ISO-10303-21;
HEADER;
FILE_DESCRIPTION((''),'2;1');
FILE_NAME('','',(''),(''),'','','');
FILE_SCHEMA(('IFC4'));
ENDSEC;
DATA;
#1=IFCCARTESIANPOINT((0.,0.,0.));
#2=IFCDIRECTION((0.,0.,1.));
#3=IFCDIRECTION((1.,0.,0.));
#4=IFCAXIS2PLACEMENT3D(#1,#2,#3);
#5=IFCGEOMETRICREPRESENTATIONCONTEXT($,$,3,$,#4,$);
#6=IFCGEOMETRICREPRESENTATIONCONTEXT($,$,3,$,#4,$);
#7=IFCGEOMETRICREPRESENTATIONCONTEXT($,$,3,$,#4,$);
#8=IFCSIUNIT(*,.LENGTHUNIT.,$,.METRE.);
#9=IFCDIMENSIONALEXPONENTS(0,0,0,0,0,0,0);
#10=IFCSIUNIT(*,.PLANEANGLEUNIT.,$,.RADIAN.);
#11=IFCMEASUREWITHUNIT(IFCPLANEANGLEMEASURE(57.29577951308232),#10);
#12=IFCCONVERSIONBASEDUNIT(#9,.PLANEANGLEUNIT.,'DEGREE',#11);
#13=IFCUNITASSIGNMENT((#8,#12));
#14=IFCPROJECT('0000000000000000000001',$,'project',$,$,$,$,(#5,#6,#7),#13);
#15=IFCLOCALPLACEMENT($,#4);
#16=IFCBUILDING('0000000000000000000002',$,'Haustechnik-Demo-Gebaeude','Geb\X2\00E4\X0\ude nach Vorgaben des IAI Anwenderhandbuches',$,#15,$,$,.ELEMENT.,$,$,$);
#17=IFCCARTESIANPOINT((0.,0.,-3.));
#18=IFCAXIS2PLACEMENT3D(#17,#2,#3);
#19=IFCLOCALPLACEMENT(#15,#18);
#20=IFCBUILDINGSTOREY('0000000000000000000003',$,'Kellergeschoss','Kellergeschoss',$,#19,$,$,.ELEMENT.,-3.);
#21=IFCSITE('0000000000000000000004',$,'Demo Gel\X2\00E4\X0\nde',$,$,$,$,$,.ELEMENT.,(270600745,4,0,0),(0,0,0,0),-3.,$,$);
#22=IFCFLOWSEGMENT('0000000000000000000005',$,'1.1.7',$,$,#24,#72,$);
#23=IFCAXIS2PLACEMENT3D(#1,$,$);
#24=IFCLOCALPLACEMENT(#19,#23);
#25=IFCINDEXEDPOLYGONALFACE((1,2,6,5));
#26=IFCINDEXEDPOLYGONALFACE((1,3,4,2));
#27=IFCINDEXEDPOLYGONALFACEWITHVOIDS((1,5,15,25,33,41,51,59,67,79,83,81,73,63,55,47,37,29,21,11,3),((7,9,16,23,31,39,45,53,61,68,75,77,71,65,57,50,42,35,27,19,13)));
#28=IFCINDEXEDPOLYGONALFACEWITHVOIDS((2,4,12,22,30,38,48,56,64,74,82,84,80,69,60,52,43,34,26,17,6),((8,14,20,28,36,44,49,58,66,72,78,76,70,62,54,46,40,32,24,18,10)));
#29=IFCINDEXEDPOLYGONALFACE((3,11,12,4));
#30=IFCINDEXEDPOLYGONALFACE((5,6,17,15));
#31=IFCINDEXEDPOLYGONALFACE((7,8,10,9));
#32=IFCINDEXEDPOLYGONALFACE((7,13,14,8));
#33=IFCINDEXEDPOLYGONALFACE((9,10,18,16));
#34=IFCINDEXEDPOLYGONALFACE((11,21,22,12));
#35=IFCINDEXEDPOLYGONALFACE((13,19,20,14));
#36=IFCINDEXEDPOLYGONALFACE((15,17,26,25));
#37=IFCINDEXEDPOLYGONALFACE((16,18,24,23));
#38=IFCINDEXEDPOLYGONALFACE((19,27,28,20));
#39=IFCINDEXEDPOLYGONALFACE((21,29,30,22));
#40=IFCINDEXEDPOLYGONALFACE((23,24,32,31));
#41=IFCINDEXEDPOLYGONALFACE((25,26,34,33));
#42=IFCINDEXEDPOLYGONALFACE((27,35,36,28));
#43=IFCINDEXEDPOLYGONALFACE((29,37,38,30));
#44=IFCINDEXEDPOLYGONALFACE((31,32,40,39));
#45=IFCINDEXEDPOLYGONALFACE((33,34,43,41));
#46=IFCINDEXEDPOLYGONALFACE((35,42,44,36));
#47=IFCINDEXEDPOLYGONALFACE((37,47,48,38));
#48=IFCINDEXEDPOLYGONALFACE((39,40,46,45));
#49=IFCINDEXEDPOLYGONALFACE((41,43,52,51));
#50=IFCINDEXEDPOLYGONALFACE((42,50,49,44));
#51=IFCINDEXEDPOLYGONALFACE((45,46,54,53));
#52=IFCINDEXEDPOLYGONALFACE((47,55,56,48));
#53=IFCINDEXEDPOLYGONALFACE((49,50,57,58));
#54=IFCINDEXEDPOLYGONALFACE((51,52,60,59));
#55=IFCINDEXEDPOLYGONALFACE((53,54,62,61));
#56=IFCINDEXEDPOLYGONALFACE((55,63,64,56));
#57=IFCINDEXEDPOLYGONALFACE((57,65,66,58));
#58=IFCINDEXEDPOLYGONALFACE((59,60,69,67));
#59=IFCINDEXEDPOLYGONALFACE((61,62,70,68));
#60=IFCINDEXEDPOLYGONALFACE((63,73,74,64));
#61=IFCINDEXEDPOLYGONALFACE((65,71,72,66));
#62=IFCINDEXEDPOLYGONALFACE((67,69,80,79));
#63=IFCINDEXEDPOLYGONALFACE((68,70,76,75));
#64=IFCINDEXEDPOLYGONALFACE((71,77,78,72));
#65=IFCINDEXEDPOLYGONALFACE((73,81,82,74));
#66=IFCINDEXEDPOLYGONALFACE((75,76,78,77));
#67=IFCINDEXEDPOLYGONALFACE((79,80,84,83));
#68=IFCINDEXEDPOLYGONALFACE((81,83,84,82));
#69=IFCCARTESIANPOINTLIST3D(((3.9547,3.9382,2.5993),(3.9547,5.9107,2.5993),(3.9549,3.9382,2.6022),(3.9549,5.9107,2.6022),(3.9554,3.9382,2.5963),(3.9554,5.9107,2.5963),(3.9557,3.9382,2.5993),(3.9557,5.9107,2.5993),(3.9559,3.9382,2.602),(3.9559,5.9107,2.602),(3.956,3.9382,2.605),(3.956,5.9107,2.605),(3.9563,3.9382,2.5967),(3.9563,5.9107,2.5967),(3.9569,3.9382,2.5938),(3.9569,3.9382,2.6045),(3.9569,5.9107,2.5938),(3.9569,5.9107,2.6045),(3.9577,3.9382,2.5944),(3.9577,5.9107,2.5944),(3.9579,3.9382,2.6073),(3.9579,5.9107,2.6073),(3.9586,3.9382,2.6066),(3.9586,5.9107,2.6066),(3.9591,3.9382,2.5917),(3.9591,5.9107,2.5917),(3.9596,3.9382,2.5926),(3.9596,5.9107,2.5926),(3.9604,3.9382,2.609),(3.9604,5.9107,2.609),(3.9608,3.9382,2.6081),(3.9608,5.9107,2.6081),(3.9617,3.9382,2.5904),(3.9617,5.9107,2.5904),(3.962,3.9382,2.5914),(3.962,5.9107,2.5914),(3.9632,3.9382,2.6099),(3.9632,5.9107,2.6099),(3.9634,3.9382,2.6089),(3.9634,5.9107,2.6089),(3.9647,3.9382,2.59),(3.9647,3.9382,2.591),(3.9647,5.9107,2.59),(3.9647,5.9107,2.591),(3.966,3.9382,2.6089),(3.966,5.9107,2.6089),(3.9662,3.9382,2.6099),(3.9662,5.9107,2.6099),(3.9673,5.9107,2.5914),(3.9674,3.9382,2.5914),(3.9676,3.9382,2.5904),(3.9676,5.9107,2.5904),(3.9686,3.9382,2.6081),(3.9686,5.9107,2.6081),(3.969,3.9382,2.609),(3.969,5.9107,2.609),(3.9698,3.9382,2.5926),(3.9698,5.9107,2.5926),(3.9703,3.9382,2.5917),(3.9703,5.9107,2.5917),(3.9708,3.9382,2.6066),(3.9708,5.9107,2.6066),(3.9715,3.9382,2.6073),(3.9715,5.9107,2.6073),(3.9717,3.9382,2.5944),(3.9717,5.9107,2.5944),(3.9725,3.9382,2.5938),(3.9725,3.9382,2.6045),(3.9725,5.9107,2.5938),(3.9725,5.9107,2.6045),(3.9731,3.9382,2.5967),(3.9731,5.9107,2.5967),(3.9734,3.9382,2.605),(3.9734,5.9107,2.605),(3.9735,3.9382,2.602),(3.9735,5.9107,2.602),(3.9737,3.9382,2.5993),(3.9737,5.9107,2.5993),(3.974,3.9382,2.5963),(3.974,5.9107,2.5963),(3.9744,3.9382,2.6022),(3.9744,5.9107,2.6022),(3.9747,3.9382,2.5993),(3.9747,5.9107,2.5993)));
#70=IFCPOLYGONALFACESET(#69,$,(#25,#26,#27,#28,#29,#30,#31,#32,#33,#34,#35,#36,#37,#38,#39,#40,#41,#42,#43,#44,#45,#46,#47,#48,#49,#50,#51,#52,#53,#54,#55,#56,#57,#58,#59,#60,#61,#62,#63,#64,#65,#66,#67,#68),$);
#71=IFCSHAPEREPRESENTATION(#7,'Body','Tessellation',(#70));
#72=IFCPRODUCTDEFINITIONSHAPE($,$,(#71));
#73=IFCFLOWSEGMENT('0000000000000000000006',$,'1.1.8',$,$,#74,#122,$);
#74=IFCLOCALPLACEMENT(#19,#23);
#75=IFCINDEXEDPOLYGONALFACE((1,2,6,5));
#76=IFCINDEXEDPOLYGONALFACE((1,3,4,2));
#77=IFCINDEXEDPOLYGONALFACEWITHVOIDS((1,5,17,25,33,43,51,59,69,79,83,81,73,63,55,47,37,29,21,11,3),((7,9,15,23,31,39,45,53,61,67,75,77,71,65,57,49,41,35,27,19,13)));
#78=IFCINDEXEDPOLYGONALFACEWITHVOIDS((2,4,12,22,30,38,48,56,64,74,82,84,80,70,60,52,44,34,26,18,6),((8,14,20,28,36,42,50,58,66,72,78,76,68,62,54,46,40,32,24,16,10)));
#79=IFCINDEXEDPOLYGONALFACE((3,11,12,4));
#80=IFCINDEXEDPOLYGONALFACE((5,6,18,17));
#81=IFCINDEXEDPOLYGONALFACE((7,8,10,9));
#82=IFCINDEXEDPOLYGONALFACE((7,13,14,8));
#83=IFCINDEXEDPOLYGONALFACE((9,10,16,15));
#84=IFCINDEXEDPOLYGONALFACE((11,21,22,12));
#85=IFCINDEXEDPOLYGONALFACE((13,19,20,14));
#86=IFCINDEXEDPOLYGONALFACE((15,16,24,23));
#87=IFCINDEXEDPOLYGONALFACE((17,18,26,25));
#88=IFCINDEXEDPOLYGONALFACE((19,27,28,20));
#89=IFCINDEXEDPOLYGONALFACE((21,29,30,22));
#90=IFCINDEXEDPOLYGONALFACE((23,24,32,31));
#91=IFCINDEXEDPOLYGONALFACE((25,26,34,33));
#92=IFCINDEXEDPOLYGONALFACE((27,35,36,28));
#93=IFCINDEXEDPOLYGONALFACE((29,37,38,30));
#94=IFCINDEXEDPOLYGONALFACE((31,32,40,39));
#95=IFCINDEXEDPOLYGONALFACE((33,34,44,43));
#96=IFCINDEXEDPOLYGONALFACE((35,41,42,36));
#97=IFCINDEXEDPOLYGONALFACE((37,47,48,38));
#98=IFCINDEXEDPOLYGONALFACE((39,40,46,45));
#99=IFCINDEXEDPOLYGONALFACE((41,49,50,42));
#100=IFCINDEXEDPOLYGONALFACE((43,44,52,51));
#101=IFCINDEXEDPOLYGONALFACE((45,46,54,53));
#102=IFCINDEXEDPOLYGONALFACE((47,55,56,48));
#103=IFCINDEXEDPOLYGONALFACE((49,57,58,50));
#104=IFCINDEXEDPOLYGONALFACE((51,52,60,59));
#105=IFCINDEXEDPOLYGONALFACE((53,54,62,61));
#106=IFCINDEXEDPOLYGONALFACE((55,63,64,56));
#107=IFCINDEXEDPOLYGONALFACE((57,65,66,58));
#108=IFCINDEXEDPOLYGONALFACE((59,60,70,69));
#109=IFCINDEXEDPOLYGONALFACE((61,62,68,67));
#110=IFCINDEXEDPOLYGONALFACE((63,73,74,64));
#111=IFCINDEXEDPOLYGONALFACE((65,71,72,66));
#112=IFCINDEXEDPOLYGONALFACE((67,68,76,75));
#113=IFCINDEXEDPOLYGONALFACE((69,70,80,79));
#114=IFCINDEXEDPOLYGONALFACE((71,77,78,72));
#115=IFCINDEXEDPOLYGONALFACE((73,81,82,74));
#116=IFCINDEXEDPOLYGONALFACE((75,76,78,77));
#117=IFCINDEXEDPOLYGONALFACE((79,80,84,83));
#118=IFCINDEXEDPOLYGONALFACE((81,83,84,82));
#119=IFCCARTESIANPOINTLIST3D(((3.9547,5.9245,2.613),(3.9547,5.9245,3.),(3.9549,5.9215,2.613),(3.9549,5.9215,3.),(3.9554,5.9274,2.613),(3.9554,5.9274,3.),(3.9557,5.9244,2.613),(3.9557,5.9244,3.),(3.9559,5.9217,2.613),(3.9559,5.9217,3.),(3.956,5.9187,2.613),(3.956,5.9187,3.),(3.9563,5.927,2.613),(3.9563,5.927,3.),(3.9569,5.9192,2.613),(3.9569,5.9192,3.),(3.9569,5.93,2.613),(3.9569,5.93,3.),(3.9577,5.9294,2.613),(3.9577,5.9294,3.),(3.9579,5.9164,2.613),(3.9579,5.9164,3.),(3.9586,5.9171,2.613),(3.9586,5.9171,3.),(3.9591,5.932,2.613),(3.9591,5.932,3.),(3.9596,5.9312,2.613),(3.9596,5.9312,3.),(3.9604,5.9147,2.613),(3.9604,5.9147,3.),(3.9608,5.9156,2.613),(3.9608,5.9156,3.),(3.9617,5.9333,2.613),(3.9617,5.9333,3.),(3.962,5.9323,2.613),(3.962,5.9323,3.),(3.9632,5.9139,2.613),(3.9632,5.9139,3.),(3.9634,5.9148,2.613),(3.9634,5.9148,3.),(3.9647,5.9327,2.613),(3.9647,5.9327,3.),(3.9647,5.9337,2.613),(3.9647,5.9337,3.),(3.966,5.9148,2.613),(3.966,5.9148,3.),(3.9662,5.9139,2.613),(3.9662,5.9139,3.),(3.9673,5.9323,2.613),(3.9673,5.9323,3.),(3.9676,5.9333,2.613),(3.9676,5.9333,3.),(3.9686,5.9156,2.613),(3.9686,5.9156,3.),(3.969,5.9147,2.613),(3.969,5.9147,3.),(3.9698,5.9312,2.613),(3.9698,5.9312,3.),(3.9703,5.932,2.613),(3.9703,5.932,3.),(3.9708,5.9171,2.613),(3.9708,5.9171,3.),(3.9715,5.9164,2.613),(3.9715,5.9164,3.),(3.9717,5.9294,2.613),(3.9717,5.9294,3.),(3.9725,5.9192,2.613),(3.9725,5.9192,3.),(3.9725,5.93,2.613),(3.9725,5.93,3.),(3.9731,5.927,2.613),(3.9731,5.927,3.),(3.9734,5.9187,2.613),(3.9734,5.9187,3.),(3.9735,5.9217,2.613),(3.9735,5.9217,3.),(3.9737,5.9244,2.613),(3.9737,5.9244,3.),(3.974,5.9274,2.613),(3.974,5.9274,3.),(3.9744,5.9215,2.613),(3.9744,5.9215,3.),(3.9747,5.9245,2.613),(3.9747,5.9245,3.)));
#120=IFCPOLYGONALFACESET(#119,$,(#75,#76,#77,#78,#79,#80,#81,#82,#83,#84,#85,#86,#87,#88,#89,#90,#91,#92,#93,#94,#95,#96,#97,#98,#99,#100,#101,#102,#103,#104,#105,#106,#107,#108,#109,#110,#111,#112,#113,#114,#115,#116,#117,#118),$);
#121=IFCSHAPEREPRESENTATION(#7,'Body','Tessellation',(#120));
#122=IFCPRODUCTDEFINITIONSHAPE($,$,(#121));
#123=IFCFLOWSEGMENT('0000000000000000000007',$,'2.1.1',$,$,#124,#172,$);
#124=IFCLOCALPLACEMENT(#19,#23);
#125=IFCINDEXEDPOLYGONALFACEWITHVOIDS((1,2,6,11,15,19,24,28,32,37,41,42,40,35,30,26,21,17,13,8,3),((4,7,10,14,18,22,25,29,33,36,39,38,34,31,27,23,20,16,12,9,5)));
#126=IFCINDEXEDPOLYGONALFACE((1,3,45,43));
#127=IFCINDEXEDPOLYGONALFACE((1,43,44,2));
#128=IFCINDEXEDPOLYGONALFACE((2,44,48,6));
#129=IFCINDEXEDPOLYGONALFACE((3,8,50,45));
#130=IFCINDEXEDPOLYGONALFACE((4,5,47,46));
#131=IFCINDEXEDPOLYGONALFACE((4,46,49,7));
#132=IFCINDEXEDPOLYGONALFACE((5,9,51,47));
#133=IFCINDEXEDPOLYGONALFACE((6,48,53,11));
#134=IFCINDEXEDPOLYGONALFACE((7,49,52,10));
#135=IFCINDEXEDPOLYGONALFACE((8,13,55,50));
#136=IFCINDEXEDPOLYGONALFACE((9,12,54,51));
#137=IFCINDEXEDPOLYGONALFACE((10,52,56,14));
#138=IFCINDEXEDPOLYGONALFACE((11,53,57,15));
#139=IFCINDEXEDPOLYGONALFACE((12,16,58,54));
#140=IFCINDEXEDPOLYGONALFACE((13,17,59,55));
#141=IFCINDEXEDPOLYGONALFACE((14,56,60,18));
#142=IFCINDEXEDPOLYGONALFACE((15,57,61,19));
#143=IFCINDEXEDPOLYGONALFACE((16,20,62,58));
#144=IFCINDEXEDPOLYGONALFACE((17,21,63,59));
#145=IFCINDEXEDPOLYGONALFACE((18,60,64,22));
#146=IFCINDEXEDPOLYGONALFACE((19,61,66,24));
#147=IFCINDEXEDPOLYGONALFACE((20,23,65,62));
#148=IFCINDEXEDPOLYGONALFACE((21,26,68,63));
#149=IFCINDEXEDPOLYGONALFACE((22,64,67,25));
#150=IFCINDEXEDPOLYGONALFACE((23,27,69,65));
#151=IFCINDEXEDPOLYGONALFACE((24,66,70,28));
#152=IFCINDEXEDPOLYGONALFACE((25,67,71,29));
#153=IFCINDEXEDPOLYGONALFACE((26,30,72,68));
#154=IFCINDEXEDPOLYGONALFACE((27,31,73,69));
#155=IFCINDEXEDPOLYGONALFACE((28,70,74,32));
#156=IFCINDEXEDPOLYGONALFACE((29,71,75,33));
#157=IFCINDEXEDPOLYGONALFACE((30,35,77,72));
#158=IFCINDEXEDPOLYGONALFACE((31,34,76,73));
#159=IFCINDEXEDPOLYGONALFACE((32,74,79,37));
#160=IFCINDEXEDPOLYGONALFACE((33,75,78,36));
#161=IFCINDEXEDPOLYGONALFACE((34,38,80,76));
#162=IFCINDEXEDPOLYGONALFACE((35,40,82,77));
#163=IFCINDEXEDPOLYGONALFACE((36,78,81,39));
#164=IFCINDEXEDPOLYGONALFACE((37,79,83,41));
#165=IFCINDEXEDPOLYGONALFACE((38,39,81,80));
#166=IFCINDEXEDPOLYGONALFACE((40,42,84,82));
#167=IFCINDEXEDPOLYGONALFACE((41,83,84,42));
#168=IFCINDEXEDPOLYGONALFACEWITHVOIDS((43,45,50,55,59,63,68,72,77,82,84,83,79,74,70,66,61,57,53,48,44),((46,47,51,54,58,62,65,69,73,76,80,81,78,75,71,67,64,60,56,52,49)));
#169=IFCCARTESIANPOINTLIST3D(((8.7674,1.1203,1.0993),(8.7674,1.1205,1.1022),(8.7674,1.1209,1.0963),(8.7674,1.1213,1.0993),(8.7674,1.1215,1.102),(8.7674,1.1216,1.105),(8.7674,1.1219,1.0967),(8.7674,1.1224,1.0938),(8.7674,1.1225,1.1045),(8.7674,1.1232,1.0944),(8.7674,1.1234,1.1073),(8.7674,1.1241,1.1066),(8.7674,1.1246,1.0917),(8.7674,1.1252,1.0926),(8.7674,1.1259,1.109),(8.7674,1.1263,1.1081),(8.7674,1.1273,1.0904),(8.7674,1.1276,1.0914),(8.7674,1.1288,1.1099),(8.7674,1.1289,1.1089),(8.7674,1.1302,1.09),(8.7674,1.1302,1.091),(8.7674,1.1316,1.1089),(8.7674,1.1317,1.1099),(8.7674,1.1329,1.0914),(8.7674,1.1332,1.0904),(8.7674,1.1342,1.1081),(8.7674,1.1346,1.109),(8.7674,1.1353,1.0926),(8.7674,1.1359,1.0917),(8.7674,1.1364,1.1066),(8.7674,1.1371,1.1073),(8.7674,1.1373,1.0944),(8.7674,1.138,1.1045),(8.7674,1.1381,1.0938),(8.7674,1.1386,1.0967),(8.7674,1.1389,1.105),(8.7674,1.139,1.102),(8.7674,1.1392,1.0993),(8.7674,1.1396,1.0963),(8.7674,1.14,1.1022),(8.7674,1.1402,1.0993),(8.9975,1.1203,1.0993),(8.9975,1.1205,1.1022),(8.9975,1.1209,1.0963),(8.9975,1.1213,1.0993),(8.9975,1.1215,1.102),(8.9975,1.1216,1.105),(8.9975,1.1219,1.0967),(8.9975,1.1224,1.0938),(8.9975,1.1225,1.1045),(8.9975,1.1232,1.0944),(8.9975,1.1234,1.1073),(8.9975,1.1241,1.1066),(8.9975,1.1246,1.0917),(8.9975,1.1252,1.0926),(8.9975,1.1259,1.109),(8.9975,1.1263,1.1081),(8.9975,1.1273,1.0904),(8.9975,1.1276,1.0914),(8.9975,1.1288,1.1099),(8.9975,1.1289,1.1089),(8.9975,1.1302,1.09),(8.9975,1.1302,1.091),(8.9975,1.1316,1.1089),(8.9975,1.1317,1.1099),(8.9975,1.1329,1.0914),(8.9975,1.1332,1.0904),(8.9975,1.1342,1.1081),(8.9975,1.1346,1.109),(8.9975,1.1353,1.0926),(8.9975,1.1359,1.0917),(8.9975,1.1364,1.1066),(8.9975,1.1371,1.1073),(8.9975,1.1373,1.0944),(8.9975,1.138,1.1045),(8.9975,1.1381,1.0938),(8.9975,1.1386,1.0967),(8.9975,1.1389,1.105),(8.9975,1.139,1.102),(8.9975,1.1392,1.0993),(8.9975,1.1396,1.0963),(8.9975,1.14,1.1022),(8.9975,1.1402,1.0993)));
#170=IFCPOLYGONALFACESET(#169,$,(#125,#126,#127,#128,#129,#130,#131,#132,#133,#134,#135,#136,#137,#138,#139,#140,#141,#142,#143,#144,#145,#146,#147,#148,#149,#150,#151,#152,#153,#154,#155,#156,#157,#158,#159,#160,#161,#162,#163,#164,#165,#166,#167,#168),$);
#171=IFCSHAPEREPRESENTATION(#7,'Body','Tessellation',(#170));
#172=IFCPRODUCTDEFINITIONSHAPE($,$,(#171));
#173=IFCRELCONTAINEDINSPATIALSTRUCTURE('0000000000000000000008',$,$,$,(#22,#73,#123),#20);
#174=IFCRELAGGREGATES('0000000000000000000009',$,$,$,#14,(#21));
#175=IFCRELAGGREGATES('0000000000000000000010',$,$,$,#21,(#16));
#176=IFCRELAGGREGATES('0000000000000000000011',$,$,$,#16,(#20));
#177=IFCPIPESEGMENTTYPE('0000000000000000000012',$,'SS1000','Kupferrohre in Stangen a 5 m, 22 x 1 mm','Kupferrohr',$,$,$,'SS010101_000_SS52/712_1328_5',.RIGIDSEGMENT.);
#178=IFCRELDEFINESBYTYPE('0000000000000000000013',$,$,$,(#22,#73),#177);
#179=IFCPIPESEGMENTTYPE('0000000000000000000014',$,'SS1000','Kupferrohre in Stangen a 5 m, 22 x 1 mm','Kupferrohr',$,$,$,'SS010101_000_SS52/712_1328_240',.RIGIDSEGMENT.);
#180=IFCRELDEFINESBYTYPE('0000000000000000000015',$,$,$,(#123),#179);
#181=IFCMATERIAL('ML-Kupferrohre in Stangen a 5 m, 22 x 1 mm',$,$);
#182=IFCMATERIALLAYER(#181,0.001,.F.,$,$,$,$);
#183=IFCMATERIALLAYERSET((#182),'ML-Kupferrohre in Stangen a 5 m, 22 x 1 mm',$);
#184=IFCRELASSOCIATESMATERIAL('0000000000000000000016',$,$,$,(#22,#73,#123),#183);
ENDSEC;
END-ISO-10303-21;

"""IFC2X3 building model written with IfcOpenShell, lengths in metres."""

from ifc_helpers import new_model, entity, si_unit, converted_unit, frame, origin_with_axes, origin_2d_with_axis, place, context, project, spatial, hollow_circle, extrude, material, layer, layer_set, layer_usage, type_object, element, save


model = new_model("IFC2X3")

# Units and contexts
context_of_model_1 = context(None, 3, world=origin_with_axes())
context_of_model_2 = context(None, 3, world=origin_with_axes())
context_of_model_3 = context(None, 3, world=origin_with_axes())
ifc_project = project(units=[si_unit("LENGTHUNIT", "METRE"), converted_unit("PLANEANGLEUNIT", "DEGREE", entity("IfcPlaneAngleMeasure", 57.29577951308232), si_unit("PLANEANGLEUNIT", "RADIAN"), dimensions=[0, 0, 0, 0, 0, 0, 0])], contexts=[context_of_model_1, context_of_model_2, context_of_model_3])

# Site, building, storey
site = spatial("IfcSite", under=ifc_project, Name="Demo Gelände", CompositionType="ELEMENT", RefLatitude=(270600745, 4, 0, 0), RefLongitude=(0, 0, 0, 0), RefElevation=-3.0)
building_placement = place(None, origin_with_axes())
building = spatial("IfcBuilding", under=site, at=building_placement, Name="Haustechnik-Demo-Gebaeude", Description="Gebäude nach Vorgaben des IAI Anwenderhandbuches", CompositionType="ELEMENT")
storey_placement = place(building_placement, frame((0.0, 0.0, -3.0), z_axis=(0.0, 0.0, 1.0), x_axis=(1.0, 0.0, 0.0)))
storey = spatial("IfcBuildingStorey", under=building, at=storey_placement, Name="Kellergeschoss", Description="Kellergeschoss", CompositionType="ELEMENT", Elevation=-3.0)

# Flow segments
ifc_material = material(Name="ML-Kupferrohre in Stangen a 5 m, 22 x 1 mm")
ifc_layer = layer(ifc_material, 0.001, ventilated=False)
ifc_layer_set = layer_set([ifc_layer], Name="ML-Kupferrohre in Stangen a 5 m, 22 x 1 mm")
ifc_layer_usage = layer_usage(ifc_layer_set, "AXIS2", "POSITIVE", 0.0)
pipe_segment_type_1 = type_object("IfcPipeSegmentType", Name="SS1000", Description="Kupferrohre in Stangen a 5 m, 22 x 1 mm", ApplicableOccurrence="Kupferrohr", ElementType="SS010101_000_SS52/712_1328_5", PredefinedType="RIGIDSEGMENT")
flow_segment_1_placement = place(storey_placement, frame((3.9647, 3.9382, 2.6), z_axis=(0.0, 1.0, 0.0), x_axis=(0.0, 0.0, -1.0)))
element("IfcFlowSegment", 1, at=flow_segment_1_placement, inside=storey, type_object=pipe_segment_type_1, material=ifc_layer_usage, Name="1.1.7", context=context_of_model_3, shape_type="SweptSolid", body=[
    extrude(hollow_circle(Radius=0.01, WallThickness=0.001, at=origin_2d_with_axis()), origin_with_axes(), (0.0, 0.0, 1.0), 1.9726),
])
flow_segment_2_placement = place(storey_placement, frame((3.9647, 5.9237, 2.613), z_axis=(0.0, 0.0, 1.0), x_axis=(0.0, 1.0, 0.0)))
element("IfcFlowSegment", 2, at=flow_segment_2_placement, inside=storey, type_object=pipe_segment_type_1, material=ifc_layer_usage, Name="1.1.8", context=context_of_model_3, shape_type="SweptSolid", body=[
    extrude(hollow_circle(Radius=0.01, WallThickness=0.001, at=origin_2d_with_axis()), origin_with_axes(), (0.0, 0.0, 1.0), 0.387),
])
pipe_segment_type_2 = type_object("IfcPipeSegmentType", Name="SS1000", Description="Kupferrohre in Stangen a 5 m, 22 x 1 mm", ApplicableOccurrence="Kupferrohr", ElementType="SS010101_000_SS52/712_1328_240", PredefinedType="RIGIDSEGMENT")
flow_segment_3_placement = place(storey_placement, frame((8.7674, 1.1302, 1.1), z_axis=(1.0, 0.0, 0.0), x_axis=(0.0, 0.0, -1.0)))
element("IfcFlowSegment", 3, at=flow_segment_3_placement, inside=storey, type_object=pipe_segment_type_2, material=ifc_layer_usage, Name="2.1.1", context=context_of_model_3, shape_type="SweptSolid", body=[
    extrude(hollow_circle(Radius=0.01, WallThickness=0.001, at=origin_2d_with_axis()), origin_with_axes(), (0.0, 0.0, 1.0), 0.2301),
])

save(model, "model.ifc")
